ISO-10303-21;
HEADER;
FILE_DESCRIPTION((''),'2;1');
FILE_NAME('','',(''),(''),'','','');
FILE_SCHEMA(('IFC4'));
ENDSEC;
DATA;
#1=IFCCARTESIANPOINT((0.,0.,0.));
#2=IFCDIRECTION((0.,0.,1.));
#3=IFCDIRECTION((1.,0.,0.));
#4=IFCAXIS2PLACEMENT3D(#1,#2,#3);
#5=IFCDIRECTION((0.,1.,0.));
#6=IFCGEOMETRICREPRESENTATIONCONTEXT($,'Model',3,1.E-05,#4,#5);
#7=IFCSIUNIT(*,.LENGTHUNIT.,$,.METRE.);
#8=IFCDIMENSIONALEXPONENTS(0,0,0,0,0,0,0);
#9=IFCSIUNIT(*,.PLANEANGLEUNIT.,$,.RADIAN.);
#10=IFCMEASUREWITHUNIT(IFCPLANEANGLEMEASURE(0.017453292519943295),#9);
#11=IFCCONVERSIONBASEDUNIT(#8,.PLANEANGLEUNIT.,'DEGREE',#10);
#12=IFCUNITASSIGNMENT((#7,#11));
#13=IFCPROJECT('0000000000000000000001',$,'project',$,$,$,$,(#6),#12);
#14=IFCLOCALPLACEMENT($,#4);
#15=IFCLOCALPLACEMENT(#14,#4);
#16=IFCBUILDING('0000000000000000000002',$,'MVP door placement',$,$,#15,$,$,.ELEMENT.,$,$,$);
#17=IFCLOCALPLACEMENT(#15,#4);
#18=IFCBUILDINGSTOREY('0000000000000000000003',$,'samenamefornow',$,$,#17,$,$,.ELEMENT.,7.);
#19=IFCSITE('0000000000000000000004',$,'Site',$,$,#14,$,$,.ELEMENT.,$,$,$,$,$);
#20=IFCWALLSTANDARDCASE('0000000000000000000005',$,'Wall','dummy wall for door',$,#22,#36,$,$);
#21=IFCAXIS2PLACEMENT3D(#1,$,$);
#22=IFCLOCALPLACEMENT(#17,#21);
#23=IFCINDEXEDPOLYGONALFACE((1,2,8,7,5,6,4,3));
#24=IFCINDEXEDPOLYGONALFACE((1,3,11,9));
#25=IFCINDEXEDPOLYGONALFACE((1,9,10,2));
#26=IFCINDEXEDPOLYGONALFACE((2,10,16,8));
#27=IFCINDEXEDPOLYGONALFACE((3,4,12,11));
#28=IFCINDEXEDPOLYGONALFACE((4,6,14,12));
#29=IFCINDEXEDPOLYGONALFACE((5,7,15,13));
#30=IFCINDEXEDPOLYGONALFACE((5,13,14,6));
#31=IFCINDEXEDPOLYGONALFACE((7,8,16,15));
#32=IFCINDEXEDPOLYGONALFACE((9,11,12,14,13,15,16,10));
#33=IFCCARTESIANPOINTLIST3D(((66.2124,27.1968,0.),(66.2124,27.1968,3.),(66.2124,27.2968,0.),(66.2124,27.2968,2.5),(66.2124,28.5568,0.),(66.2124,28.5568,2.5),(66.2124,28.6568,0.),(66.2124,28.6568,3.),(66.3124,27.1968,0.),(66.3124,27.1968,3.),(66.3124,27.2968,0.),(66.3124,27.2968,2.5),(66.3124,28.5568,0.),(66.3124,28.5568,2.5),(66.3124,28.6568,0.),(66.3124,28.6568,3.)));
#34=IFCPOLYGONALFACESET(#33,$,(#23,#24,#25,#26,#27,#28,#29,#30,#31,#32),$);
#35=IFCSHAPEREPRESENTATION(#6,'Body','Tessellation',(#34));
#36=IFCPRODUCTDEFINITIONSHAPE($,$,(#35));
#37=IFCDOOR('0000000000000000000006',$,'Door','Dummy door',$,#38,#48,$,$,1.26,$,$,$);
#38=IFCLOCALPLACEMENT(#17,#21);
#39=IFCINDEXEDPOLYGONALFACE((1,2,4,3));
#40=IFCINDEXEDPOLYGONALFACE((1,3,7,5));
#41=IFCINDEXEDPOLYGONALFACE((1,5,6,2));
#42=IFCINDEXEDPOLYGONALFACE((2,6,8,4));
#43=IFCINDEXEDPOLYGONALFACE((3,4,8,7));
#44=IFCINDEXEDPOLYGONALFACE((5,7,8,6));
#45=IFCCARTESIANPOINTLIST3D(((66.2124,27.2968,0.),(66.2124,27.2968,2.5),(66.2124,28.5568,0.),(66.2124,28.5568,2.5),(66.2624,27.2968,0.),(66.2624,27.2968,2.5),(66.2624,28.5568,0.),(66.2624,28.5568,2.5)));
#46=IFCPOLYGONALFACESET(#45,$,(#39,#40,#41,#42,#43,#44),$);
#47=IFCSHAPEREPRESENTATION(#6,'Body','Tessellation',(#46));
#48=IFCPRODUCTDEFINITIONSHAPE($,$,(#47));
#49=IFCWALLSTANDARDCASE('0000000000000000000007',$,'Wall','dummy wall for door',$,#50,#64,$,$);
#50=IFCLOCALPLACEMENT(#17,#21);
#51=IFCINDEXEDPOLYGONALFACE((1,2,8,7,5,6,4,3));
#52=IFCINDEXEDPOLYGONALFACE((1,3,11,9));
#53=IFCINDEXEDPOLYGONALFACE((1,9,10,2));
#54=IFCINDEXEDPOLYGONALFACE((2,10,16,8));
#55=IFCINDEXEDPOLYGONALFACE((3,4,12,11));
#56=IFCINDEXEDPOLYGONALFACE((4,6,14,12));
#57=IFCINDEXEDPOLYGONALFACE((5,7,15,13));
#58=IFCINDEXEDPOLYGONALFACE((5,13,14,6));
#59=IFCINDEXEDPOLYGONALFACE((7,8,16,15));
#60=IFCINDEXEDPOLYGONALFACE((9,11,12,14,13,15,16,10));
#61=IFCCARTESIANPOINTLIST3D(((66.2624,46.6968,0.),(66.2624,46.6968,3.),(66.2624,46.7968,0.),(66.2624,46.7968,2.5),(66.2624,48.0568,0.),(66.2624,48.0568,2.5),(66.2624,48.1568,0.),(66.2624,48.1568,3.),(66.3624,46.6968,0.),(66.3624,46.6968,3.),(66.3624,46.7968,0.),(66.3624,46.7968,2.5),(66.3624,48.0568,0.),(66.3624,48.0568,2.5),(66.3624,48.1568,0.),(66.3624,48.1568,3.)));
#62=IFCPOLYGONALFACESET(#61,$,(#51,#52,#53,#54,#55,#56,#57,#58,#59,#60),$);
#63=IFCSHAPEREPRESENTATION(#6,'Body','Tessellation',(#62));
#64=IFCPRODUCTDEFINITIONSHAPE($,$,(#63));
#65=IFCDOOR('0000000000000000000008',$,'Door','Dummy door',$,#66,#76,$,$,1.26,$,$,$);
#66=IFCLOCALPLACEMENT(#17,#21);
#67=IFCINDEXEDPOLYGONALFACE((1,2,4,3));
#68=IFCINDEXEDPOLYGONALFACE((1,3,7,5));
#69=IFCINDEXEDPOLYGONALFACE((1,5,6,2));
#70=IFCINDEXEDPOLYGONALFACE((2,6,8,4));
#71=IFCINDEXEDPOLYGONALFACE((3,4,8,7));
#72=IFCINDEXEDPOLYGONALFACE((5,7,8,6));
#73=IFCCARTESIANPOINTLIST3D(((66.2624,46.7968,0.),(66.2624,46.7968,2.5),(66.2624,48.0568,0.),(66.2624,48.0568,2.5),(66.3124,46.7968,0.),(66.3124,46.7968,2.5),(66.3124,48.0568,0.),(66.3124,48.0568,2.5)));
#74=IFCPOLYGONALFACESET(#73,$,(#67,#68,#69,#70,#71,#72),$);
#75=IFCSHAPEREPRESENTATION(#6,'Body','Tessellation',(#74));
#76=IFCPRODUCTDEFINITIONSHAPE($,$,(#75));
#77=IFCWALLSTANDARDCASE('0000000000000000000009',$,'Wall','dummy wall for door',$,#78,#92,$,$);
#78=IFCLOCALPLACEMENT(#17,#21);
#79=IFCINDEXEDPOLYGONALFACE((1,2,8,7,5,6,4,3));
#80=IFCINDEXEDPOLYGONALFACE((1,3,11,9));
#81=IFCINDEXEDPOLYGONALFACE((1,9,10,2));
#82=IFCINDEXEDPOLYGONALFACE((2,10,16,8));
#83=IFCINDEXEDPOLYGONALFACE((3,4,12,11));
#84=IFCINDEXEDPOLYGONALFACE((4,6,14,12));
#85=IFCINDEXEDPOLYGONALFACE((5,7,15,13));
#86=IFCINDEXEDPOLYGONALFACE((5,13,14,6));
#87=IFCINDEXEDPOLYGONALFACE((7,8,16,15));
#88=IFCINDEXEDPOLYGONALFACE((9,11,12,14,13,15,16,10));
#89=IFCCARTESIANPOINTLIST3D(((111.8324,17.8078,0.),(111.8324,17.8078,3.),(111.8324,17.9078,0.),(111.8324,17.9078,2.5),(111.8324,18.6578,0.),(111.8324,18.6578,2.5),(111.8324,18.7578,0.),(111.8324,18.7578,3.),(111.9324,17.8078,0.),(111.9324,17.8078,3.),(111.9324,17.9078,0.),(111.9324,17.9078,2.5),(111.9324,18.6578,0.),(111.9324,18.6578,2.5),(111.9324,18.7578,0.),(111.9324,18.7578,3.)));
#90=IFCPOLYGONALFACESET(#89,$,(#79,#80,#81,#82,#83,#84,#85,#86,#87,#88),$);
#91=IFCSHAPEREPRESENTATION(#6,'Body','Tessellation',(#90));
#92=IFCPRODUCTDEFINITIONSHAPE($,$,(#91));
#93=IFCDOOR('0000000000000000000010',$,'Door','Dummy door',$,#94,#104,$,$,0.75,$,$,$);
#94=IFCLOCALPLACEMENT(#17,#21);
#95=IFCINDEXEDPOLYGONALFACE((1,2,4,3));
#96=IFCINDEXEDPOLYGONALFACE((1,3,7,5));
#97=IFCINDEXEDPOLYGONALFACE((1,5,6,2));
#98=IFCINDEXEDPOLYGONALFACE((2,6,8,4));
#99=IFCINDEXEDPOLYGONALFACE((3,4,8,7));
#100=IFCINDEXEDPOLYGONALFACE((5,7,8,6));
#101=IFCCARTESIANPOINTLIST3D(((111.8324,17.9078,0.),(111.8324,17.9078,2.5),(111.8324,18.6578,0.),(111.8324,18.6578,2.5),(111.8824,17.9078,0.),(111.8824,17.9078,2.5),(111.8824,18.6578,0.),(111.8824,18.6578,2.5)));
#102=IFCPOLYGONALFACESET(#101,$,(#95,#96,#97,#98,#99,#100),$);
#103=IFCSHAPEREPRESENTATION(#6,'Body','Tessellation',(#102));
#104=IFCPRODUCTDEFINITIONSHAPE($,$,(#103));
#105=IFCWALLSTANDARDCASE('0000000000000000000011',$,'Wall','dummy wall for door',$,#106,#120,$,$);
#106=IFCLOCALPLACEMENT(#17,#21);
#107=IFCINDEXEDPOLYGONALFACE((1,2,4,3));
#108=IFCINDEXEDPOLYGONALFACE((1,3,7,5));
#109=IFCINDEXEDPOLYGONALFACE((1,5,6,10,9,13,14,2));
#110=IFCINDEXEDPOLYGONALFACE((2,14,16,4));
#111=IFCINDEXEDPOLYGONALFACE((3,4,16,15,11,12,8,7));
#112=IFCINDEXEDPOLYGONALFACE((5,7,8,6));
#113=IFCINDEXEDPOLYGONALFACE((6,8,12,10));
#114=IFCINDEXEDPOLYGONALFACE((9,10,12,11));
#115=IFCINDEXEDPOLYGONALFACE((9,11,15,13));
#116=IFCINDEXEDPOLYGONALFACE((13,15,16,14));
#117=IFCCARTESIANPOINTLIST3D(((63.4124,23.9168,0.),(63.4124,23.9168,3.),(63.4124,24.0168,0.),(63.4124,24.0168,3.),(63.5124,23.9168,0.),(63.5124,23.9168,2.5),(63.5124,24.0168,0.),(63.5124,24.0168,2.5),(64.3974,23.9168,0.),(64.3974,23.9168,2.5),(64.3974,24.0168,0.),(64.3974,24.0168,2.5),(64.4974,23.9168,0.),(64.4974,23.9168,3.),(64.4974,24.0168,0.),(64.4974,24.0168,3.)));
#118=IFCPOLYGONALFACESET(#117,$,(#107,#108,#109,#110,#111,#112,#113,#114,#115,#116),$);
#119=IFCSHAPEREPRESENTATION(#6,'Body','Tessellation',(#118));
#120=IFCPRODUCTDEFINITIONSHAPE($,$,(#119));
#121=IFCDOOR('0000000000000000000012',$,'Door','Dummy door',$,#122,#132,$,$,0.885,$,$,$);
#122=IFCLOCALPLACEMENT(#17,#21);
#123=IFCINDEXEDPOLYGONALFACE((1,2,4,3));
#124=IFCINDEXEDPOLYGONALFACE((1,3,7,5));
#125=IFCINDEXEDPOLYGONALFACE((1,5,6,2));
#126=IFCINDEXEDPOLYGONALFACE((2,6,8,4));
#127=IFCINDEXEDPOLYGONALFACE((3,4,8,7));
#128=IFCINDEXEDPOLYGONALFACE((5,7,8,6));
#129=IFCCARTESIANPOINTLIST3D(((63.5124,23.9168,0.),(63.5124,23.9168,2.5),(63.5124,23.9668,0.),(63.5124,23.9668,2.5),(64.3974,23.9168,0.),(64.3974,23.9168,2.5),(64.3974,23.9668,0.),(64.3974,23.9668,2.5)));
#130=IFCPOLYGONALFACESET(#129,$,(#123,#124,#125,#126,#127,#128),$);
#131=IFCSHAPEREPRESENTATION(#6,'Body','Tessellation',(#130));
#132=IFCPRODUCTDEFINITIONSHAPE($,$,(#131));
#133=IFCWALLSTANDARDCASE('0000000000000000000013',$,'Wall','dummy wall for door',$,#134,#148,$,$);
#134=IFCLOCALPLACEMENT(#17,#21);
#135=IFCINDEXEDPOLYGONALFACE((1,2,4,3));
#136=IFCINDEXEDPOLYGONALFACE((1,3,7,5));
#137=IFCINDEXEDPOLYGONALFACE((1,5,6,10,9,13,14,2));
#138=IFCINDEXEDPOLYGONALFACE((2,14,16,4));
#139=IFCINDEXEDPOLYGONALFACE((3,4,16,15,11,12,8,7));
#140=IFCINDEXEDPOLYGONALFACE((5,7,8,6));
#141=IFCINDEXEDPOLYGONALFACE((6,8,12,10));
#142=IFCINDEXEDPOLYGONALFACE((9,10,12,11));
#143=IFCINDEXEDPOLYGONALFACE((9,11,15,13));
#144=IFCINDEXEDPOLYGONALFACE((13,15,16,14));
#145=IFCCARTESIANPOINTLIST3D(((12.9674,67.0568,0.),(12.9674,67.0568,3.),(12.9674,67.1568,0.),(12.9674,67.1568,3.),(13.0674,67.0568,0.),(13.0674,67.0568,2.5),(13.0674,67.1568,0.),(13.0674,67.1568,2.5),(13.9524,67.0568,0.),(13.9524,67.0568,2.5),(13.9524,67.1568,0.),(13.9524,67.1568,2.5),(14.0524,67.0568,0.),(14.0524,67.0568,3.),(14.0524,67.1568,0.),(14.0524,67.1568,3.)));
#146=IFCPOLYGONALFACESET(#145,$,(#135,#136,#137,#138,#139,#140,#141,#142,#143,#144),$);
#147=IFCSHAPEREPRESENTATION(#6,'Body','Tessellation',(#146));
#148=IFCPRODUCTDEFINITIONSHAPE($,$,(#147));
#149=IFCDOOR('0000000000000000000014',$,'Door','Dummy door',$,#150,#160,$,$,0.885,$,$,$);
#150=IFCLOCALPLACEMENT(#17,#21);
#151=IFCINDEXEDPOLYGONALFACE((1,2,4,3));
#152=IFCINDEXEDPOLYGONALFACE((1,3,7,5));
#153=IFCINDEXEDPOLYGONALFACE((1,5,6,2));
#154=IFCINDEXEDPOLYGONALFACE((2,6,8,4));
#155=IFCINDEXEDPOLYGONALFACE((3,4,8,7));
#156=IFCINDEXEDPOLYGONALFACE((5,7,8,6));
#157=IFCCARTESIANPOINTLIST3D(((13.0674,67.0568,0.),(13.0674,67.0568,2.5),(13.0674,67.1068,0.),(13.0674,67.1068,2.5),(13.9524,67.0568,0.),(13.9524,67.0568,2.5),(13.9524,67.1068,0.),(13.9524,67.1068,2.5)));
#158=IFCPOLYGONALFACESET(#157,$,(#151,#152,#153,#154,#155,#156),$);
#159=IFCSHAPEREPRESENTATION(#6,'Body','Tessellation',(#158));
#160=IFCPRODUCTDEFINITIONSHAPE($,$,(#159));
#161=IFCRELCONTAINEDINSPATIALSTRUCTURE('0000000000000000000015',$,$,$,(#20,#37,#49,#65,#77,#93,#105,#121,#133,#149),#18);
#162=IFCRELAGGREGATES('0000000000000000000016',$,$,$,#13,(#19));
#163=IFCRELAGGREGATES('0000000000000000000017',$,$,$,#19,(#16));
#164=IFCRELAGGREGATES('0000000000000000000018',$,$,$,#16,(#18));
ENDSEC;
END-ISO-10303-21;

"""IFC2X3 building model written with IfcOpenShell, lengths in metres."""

from ifc_helpers import new_model, entity, si_unit, converted_unit, direction, origin_with_axes, place, context, project, spatial, polyline, outline, extrude, element, fill, save


model = new_model("IFC2X3")

# Units and contexts
model_context = context("Model", 3, precision=1e-05, world=origin_with_axes(), true_north=direction((0.0, 1.0, 0.0)))
ifc_project = project(units=[si_unit("LENGTHUNIT", "METRE"), converted_unit("PLANEANGLEUNIT", "DEGREE", entity("IfcPlaneAngleMeasure", 0.017453292519943295), si_unit("PLANEANGLEUNIT", "RADIAN"), dimensions=[0, 0, 0, 0, 0, 0, 0])], contexts=[model_context])

# Site, building, storey
site_placement = place(None, origin_with_axes())
site = spatial("IfcSite", under=ifc_project, at=site_placement, Name="Site", CompositionType="ELEMENT")
building_placement = place(site_placement, origin_with_axes())
building = spatial("IfcBuilding", under=site, at=building_placement, Name="MVP door placement", CompositionType="ELEMENT")
storey_placement = place(building_placement, origin_with_axes())
storey = spatial("IfcBuildingStorey", under=building, at=storey_placement, Name="samenamefornow", CompositionType="ELEMENT", Elevation=7.0)

# Walls, openings, doors
wall_1_placement = place(storey_placement, origin_with_axes())
wall_1 = element("IfcWallStandardCase", 1, at=wall_1_placement, inside=storey, Name="Wall", Description="dummy wall for door", context=model_context, shape_type="SweptSolid", body=[
    extrude(outline(polyline([(66.2124, 28.6568, 0.0), (66.2124, 27.1968, 0.0), (66.3124, 27.1968, 0.0), (66.3124, 28.6568, 0.0), (66.2124, 28.6568, 0.0)])), origin_with_axes(), (0.0, 0.0, 1.0), 3.0),
])
opening_1_placement = place(wall_1_placement, origin_with_axes())
opening_1 = element("IfcOpeningElement", 2, at=opening_1_placement, cuts=wall_1, context=model_context, shape_type="SweptSolid", body=[
    extrude(outline(polyline([(66.2124, 28.5568, 0.0), (66.2124, 27.2968, 0.0), (66.3124, 27.2968, 0.0), (66.3124, 28.5568, 0.0), (66.2124, 28.5568, 0.0)])), origin_with_axes(), (0.0, 0.0, 1.0), 2.5),
])
door_1_placement = place(opening_1_placement, origin_with_axes())
door_1 = element("IfcDoor", 3, at=door_1_placement, inside=storey, Name="Door", Description="Dummy door", OverallWidth=1.26, context=model_context, shape_type="SweptSolid", body=[
    extrude(outline(polyline([(66.2124, 28.5568, 0.0), (66.2124, 27.2968, 0.0), (66.2624, 27.2968, 0.0), (66.2624, 28.5568, 0.0), (66.2124, 28.5568, 0.0)])), origin_with_axes(), (0.0, 0.0, 1.0), 2.5),
])
fill(opening_1, door_1)
wall_2_placement = place(storey_placement, origin_with_axes())
wall_2 = element("IfcWallStandardCase", 4, at=wall_2_placement, inside=storey, Name="Wall", Description="dummy wall for door", context=model_context, shape_type="SweptSolid", body=[
    extrude(outline(polyline([(66.2624, 46.6968, 0.0), (66.2624, 48.1568, 0.0), (66.3624, 48.1568, 0.0), (66.3624, 46.6968, 0.0), (66.2624, 46.6968, 0.0)])), origin_with_axes(), (0.0, 0.0, 1.0), 3.0),
])
opening_2_placement = place(wall_2_placement, origin_with_axes())
opening_2 = element("IfcOpeningElement", 5, at=opening_2_placement, cuts=wall_2, context=model_context, shape_type="SweptSolid", body=[
    extrude(outline(polyline([(66.2624, 46.7968, 0.0), (66.2624, 48.0568, 0.0), (66.3624, 48.0568, 0.0), (66.3624, 46.7968, 0.0), (66.2624, 46.7968, 0.0)])), origin_with_axes(), (0.0, 0.0, 1.0), 2.5),
])
door_2_placement = place(opening_2_placement, origin_with_axes())
door_2 = element("IfcDoor", 6, at=door_2_placement, inside=storey, Name="Door", Description="Dummy door", OverallWidth=1.26, context=model_context, shape_type="SweptSolid", body=[
    extrude(outline(polyline([(66.2624, 46.7968, 0.0), (66.2624, 48.0568, 0.0), (66.3124, 48.0568, 0.0), (66.3124, 46.7968, 0.0), (66.2624, 46.7968, 0.0)])), origin_with_axes(), (0.0, 0.0, 1.0), 2.5),
])
fill(opening_2, door_2)
wall_3_placement = place(storey_placement, origin_with_axes())
wall_3 = element("IfcWallStandardCase", 7, at=wall_3_placement, inside=storey, Name="Wall", Description="dummy wall for door", context=model_context, shape_type="SweptSolid", body=[
    extrude(outline(polyline([(111.8324, 18.7578, 0.0), (111.8324, 17.8078, 0.0), (111.9324, 17.8078, 0.0), (111.9324, 18.7578, 0.0), (111.8324, 18.7578, 0.0)])), origin_with_axes(), (0.0, 0.0, 1.0), 3.0),
])
opening_3_placement = place(wall_3_placement, origin_with_axes())
opening_3 = element("IfcOpeningElement", 8, at=opening_3_placement, cuts=wall_3, context=model_context, shape_type="SweptSolid", body=[
    extrude(outline(polyline([(111.8324, 18.6578, 0.0), (111.8324, 17.9078, 0.0), (111.9324, 17.9078, 0.0), (111.9324, 18.6578, 0.0), (111.8324, 18.6578, 0.0)])), origin_with_axes(), (0.0, 0.0, 1.0), 2.5),
])
door_3_placement = place(opening_3_placement, origin_with_axes())
door_3 = element("IfcDoor", 9, at=door_3_placement, inside=storey, Name="Door", Description="Dummy door", OverallWidth=0.75, context=model_context, shape_type="SweptSolid", body=[
    extrude(outline(polyline([(111.8324, 18.6578, 0.0), (111.8324, 17.9078, 0.0), (111.8824, 17.9078, 0.0), (111.8824, 18.6578, 0.0), (111.8324, 18.6578, 0.0)])), origin_with_axes(), (0.0, 0.0, 1.0), 2.5),
])
fill(opening_3, door_3)
wall_4_placement = place(storey_placement, origin_with_axes())
wall_4 = element("IfcWallStandardCase", 10, at=wall_4_placement, inside=storey, Name="Wall", Description="dummy wall for door", context=model_context, shape_type="SweptSolid", body=[
    extrude(outline(polyline([(63.4124, 23.9168, 0.0), (64.4974, 23.9168, 0.0), (64.4974, 24.0168, 0.0), (63.4124, 24.0168, 0.0), (63.4124, 23.9168, 0.0)])), origin_with_axes(), (0.0, 0.0, 1.0), 3.0),
])
opening_4_placement = place(wall_4_placement, origin_with_axes())
opening_4 = element("IfcOpeningElement", 11, at=opening_4_placement, cuts=wall_4, context=model_context, shape_type="SweptSolid", body=[
    extrude(outline(polyline([(63.5124, 23.9168, 0.0), (64.3974, 23.9168, 0.0), (64.3974, 24.0168, 0.0), (63.5124, 24.0168, 0.0), (63.5124, 23.9168, 0.0)])), origin_with_axes(), (0.0, 0.0, 1.0), 2.5),
])
door_4_placement = place(opening_4_placement, origin_with_axes())
door_4 = element("IfcDoor", 12, at=door_4_placement, inside=storey, Name="Door", Description="Dummy door", OverallWidth=0.885, context=model_context, shape_type="SweptSolid", body=[
    extrude(outline(polyline([(63.5124, 23.9168, 0.0), (64.3974, 23.9168, 0.0), (64.3974, 23.9668, 0.0), (63.5124, 23.9668, 0.0), (63.5124, 23.9168, 0.0)])), origin_with_axes(), (0.0, 0.0, 1.0), 2.5),
])
fill(opening_4, door_4)
wall_5_placement = place(storey_placement, origin_with_axes())
wall_5 = element("IfcWallStandardCase", 13, at=wall_5_placement, inside=storey, Name="Wall", Description="dummy wall for door", context=model_context, shape_type="SweptSolid", body=[
    extrude(outline(polyline([(12.9674, 67.0568, 0.0), (14.0524, 67.0568, 0.0), (14.0524, 67.1568, 0.0), (12.9674, 67.1568, 0.0), (12.9674, 67.0568, 0.0)])), origin_with_axes(), (0.0, 0.0, 1.0), 3.0),
])
opening_5_placement = place(wall_5_placement, origin_with_axes())
opening_5 = element("IfcOpeningElement", 14, at=opening_5_placement, cuts=wall_5, context=model_context, shape_type="SweptSolid", body=[
    extrude(outline(polyline([(13.0674, 67.0568, 0.0), (13.9524, 67.0568, 0.0), (13.9524, 67.1568, 0.0), (13.0674, 67.1568, 0.0), (13.0674, 67.0568, 0.0)])), origin_with_axes(), (0.0, 0.0, 1.0), 2.5),
])
door_5_placement = place(opening_5_placement, origin_with_axes())
door_5 = element("IfcDoor", 15, at=door_5_placement, inside=storey, Name="Door", Description="Dummy door", OverallWidth=0.885, context=model_context, shape_type="SweptSolid", body=[
    extrude(outline(polyline([(13.0674, 67.0568, 0.0), (13.9524, 67.0568, 0.0), (13.9524, 67.1068, 0.0), (13.0674, 67.1068, 0.0), (13.0674, 67.0568, 0.0)])), origin_with_axes(), (0.0, 0.0, 1.0), 2.5),
])
fill(opening_5, door_5)

save(model, "model.ifc")
